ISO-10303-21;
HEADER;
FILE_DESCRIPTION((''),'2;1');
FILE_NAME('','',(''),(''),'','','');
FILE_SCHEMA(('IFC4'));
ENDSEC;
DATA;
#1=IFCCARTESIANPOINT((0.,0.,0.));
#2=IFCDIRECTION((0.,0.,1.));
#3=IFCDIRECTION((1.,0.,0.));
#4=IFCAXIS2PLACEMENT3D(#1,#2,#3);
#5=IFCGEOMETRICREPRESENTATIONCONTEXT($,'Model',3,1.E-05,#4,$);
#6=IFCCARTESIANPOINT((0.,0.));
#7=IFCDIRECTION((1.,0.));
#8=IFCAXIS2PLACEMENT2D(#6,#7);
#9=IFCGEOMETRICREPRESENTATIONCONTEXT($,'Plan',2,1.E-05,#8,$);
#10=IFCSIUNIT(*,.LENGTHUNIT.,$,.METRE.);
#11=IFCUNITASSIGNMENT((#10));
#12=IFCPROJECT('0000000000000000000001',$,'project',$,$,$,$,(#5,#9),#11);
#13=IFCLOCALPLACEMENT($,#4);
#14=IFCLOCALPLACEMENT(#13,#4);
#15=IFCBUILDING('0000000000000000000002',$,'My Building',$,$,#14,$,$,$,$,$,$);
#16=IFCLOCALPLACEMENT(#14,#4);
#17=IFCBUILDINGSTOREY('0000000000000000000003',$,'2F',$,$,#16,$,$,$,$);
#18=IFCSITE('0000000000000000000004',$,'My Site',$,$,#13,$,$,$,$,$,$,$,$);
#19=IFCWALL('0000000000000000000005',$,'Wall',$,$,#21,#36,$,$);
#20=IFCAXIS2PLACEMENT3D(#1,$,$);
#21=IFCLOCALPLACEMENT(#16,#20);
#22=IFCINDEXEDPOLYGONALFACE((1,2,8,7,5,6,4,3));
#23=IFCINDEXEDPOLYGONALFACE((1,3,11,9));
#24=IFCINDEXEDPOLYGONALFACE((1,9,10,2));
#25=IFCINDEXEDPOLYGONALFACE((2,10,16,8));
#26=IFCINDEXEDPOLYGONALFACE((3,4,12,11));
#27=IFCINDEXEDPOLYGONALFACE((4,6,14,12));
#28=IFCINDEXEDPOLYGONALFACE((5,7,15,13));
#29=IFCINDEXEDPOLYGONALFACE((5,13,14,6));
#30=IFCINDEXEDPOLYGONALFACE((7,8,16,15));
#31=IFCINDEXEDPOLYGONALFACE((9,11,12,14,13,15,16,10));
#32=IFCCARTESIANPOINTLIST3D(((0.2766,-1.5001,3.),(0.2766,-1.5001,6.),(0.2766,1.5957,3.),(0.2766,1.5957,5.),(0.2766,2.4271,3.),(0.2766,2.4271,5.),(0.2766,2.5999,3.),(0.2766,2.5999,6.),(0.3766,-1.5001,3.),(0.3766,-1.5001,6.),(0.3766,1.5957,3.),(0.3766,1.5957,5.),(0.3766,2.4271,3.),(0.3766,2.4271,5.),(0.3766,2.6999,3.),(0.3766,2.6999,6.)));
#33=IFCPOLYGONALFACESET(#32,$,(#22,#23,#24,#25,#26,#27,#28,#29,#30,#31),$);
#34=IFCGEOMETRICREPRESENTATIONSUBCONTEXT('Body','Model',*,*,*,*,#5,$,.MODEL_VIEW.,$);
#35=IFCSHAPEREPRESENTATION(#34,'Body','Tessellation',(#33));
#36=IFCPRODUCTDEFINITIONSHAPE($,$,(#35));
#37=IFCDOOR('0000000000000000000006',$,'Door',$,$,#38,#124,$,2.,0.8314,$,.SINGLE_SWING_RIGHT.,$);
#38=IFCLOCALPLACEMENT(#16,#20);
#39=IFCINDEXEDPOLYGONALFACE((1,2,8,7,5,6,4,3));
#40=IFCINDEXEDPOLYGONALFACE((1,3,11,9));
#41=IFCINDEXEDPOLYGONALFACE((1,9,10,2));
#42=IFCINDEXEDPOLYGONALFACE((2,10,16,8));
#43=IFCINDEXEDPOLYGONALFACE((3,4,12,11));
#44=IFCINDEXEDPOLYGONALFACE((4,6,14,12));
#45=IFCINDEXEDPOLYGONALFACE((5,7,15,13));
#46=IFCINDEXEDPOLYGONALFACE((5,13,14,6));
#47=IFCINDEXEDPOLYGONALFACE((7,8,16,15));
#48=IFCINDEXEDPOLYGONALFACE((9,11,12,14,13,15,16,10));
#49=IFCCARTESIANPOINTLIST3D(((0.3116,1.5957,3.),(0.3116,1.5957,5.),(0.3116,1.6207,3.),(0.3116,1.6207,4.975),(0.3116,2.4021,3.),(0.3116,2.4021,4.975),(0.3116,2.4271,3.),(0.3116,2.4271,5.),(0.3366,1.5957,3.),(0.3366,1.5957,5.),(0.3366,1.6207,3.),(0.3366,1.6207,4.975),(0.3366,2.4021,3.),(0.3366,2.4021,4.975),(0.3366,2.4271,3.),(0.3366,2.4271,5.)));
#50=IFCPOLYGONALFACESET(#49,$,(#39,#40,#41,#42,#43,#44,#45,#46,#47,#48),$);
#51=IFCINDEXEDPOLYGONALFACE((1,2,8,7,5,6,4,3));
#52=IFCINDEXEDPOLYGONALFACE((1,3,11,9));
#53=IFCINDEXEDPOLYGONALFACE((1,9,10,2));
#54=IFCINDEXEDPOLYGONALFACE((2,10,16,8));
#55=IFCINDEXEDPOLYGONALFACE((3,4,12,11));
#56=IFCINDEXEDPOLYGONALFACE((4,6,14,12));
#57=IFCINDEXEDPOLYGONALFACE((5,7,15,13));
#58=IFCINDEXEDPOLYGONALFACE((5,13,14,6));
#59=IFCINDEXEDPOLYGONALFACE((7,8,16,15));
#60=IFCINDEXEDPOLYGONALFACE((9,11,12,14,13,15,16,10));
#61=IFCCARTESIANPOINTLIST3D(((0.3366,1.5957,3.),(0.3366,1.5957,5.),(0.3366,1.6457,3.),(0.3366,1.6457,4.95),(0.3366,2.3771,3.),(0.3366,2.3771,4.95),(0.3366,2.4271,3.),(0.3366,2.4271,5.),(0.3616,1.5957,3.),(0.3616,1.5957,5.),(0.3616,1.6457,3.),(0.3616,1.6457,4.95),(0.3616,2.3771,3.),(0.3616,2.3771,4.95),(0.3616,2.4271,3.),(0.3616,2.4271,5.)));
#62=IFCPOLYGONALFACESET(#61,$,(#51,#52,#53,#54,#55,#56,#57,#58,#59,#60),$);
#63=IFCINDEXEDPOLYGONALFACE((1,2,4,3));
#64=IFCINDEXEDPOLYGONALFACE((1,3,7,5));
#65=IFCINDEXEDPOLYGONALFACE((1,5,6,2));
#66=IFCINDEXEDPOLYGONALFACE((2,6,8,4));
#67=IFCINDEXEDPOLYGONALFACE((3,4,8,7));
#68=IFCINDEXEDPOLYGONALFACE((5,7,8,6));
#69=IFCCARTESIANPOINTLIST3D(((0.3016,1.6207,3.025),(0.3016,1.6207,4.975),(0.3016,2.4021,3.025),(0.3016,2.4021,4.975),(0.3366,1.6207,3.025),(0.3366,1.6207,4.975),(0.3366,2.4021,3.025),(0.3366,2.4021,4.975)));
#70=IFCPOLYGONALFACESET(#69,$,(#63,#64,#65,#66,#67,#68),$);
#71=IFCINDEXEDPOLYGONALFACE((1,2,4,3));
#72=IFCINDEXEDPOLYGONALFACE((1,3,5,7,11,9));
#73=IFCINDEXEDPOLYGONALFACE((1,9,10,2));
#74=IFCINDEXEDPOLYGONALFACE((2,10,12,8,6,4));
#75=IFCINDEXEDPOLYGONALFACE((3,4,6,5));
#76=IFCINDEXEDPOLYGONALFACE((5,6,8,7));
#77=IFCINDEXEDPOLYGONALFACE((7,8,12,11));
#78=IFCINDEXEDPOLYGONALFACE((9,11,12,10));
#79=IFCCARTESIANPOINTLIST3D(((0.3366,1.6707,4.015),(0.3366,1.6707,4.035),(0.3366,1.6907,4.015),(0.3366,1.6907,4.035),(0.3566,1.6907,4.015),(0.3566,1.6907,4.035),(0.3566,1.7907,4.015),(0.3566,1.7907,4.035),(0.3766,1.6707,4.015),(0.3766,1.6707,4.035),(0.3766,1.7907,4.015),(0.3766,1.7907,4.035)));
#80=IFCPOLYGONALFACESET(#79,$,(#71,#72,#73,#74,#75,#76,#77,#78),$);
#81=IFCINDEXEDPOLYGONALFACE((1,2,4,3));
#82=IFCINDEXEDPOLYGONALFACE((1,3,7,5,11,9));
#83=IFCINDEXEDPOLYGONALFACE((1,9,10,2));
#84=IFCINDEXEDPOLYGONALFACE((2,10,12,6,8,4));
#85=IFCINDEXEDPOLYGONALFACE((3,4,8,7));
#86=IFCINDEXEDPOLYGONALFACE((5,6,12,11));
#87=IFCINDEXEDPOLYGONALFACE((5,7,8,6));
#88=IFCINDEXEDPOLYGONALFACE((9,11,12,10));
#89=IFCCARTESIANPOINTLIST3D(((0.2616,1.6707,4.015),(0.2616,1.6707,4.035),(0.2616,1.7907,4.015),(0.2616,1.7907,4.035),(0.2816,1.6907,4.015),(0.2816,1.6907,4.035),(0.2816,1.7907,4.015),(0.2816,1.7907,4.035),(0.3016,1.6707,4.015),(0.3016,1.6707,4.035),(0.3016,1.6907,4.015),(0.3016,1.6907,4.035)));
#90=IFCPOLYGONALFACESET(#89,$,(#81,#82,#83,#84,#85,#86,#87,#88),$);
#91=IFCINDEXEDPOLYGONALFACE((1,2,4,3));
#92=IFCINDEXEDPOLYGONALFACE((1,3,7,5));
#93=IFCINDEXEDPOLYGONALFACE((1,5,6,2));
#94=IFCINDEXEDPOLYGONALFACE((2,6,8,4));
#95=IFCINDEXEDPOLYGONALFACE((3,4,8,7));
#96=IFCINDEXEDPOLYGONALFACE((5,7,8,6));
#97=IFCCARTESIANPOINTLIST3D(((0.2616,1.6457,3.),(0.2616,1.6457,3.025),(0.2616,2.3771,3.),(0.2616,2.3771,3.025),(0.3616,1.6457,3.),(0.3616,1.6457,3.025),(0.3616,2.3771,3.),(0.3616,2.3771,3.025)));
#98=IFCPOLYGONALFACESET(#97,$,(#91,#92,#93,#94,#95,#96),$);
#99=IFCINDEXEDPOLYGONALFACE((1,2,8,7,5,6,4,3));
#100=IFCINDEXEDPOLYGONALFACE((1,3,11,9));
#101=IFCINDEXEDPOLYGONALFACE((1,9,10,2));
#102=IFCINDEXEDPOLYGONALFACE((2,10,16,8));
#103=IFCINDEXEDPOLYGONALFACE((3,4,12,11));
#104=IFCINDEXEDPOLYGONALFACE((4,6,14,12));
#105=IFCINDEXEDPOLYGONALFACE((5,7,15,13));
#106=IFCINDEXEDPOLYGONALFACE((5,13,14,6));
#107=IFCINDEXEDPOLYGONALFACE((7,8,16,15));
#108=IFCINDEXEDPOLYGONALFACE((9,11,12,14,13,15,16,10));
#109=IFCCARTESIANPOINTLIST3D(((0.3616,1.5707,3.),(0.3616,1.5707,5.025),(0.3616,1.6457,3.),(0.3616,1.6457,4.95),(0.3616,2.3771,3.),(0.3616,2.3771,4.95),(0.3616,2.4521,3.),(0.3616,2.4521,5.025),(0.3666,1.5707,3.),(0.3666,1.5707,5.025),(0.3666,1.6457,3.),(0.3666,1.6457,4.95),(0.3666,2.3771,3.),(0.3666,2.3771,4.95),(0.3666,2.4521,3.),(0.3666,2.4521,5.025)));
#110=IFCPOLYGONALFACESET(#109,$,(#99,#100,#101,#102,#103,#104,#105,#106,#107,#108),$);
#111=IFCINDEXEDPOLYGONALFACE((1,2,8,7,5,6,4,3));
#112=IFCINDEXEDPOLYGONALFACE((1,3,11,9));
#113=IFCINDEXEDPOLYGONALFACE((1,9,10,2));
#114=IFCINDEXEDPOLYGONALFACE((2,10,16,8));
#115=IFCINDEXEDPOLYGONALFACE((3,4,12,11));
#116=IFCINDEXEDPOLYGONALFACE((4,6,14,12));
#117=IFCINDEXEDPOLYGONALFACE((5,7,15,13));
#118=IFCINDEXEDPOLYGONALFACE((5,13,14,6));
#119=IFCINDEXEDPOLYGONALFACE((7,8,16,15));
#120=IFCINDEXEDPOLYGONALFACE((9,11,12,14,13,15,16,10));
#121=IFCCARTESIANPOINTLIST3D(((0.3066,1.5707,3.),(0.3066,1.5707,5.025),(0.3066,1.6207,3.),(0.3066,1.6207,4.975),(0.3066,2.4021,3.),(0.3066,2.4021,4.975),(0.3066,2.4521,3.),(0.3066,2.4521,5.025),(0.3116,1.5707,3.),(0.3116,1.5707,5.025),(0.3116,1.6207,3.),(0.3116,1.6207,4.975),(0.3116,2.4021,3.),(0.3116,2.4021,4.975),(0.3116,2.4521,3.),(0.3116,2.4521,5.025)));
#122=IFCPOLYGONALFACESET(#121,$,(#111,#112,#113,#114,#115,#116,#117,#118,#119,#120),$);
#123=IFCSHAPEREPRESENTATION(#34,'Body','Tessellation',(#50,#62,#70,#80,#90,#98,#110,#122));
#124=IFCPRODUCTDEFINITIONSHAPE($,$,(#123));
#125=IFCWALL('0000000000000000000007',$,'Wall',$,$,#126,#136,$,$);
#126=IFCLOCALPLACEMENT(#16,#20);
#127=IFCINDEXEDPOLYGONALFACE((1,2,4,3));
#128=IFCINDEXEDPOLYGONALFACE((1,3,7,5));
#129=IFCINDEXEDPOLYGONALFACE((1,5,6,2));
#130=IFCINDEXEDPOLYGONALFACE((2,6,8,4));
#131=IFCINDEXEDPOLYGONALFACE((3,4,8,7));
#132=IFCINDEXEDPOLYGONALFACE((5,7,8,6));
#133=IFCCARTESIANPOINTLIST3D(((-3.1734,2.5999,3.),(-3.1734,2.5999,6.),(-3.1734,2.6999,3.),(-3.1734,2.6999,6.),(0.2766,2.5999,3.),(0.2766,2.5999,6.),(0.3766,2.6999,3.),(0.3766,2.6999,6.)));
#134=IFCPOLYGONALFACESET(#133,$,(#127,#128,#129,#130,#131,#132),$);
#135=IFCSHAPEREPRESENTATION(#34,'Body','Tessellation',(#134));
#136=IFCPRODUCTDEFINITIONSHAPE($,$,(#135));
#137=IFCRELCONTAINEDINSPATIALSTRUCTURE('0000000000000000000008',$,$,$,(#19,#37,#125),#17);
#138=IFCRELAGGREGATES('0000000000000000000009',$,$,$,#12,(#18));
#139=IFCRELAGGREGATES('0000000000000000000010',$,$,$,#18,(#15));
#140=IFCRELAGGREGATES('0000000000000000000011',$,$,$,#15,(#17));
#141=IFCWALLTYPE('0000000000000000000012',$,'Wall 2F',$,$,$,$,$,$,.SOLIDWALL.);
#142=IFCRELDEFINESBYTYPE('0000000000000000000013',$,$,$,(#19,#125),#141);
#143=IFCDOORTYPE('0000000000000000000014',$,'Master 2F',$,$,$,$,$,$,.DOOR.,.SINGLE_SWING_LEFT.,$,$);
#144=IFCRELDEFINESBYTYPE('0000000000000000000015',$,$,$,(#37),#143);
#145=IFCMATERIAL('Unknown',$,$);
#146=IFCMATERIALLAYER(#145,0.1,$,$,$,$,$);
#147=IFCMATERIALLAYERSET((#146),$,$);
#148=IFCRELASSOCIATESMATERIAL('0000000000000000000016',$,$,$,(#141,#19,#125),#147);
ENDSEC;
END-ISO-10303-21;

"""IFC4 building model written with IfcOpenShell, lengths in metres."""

from ifc_helpers import new_model, entity, si_unit, frame, origin_with_axes, origin_2d_with_axis, place, context, subcontext, project, spatial, line, indexed_curve, outline, extrude, shape, source, transform, mapped, material, layer, layer_set, layer_usage, type_object, type_shapes, element, fill, save


model = new_model("IFC4")

# Units and contexts
model_context = context("Model", 3, precision=1e-05, world=origin_with_axes())
plan_context = context("Plan", 2, precision=1e-05, world=origin_2d_with_axis())
body_context_1 = subcontext(model_context, "Body", "Model", "MODEL_VIEW")
body_context_2 = subcontext(plan_context, "Body", "Plan", "PLAN_VIEW")
ifc_project = project(units=[si_unit("LENGTHUNIT", "METRE")], contexts=[model_context, plan_context])

# Site, building, storey
site_placement = place(None, origin_with_axes())
site = spatial("IfcSite", under=ifc_project, at=site_placement, Name="My Site")
building_placement = place(site_placement, origin_with_axes())
building = spatial("IfcBuilding", under=site, at=building_placement, Name="My Building")
storey_placement = place(building_placement, origin_with_axes())
storey = spatial("IfcBuildingStorey", under=building, at=storey_placement, Name="2F")

# Shared definitions
ifc_material = material(Name="Unknown")

# Shared definitions
ifc_layer = layer(ifc_material, 0.1)
ifc_layer_set = layer_set([ifc_layer])
wall_type = type_object("IfcWallType", Name="Wall 2F", PredefinedType="SOLIDWALL", material=ifc_layer_set)

# Wall, opening, door
ifc_layer_usage_1 = layer_usage(ifc_layer_set, "AXIS2", "POSITIVE", 0.0)
wall_1_placement = place(storey_placement, frame((0.3766, -1.6001, 3.0), z_axis=(0.0, 0.0, 1.0), x_axis=(0.0, 1.0, 0.0)))
wall_1 = element("IfcWall", 1, at=wall_1_placement, inside=storey, type_object=wall_type, material=ifc_layer_usage_1, Name="Wall", context=body_context_1, shape_type="SweptSolid", body=[
    extrude(outline(indexed_curve([(0.1, 0.0), (0.1, 0.1), (4.2, 0.1), (4.3, 0.0)], segments=[line(1, 2, 3, 4, 1)])), origin_with_axes(), (0.0, 0.0, 1.0), 3.0),
])
shared_shape_1 = source(origin_with_axes(), body_context_1, "Body", "SweptSolid", [
    extrude(outline(indexed_curve([(0.0, 0.0), (0.8314, 0.0), (0.8314, 2.0), (0.0, 2.0)], segments=[line(1, 2, 3, 4, 1)])), frame((0.0, -0.6, 0.0), z_axis=(0.0, -1.0, 0.0), x_axis=(1.0, 0.0, 0.0)), (0.0, 0.0, -1.0), 1.2),
])
opening_1_placement = place(wall_1_placement, frame((3.1958, 0.015, 0.0), z_axis=(0.0, 0.0, 1.0), x_axis=(1.0, 0.0, 0.0)))
opening_1 = element("IfcOpeningElement", 2, at=opening_1_placement, cuts=wall_1, PredefinedType="OPENING", context=body_context_1, shape_type="MappedRepresentation", body=[
    mapped(shared_shape_1, transform((0.0, 0.0, 0.0), x_axis=(1.0, 0.0, 0.0), y_axis=(0.0, 1.0, 0.0), z_axis=(0.0, 0.0, 1.0), scale=1.0)),
])
door_type_1 = type_object("IfcDoorType", Name="Master 2F", OperationType="SINGLE_SWING_LEFT", PredefinedType="DOOR")
shared_shape_2 = source(origin_with_axes(), body_context_1, "Body", "SweptSolid", [
    extrude(outline(indexed_curve([(0.0, 0.0), (0.0, 2.0), (0.8314, 2.0), (0.8314, 0.0), (0.8064, 0.0), (0.8064, 1.975), (0.025, 1.975), (0.025, 0.0)], segments=[line(1, 2, 3, 4, 5, 6, 7, 8, 1)])), frame((0.0, 0.025, 0.0), z_axis=(0.0, -1.0, 0.0), x_axis=(1.0, 0.0, 0.0)), (0.0, 0.0, -1.0), 0.025),
    extrude(outline(indexed_curve([(0.0, 0.0), (0.0, 2.0), (0.8314, 2.0), (0.8314, 0.0), (0.7814, 0.0), (0.7814, 1.95), (0.05, 1.95), (0.05, 0.0)], segments=[line(1, 2, 3, 4, 5, 6, 7, 8, 1)])), frame((0.0, 0.0, 0.0), z_axis=(0.0, -1.0, 0.0), x_axis=(1.0, 0.0, 0.0)), (0.0, 0.0, -1.0), 0.025),
    extrude(outline(indexed_curve([(0.0, 0.0), (0.7814, 0.0), (0.7814, 0.035), (0.0, 0.035)], segments=[line(1, 2, 3, 4, 1)])), frame((0.025, 0.025, 0.025), z_axis=(0.0, 0.0, 1.0), x_axis=(1.0, 0.0, 0.0)), (0.0, 0.0, 1.0), 1.95),
    extrude(outline(indexed_curve([(0.0, 0.0), (0.0, -0.04), (0.12, -0.04), (0.12, -0.02), (0.02, -0.02), (0.02, 0.0)], segments=[line(1, 2, 3, 4, 5, 6, 1)])), frame((0.075, 0.025, 1.015), z_axis=(0.0, 0.0, 1.0), x_axis=(1.0, 0.0, 0.0)), (0.0, 0.0, 1.0), 0.02),
    extrude(outline(indexed_curve([(0.0, 0.0), (0.0, 0.04), (0.12, 0.04), (0.12, 0.02), (0.02, 0.02), (0.02, 0.0)], segments=[line(1, 2, 3, 4, 5, 6, 1)])), frame((0.075, 0.06, 1.015), z_axis=(0.0, 0.0, 1.0), x_axis=(1.0, 0.0, 0.0)), (0.0, 0.0, 1.0), 0.02),
    extrude(outline(indexed_curve([(0.0, 0.0), (0.7314, 0.0), (0.7314, 0.1), (0.0, 0.1)], segments=[line(1, 2, 3, 4, 1)])), frame((0.05, 0.0, 0.0), z_axis=(0.0, 0.0, 1.0), x_axis=(1.0, 0.0, 0.0)), (0.0, 0.0, 1.0), 0.025),
    extrude(outline(indexed_curve([(0.0, 0.0), (0.0, 2.025), (0.8814, 2.025), (0.8814, 0.0), (0.8064, 0.0), (0.8064, 1.95), (0.075, 1.95), (0.075, 0.0)], segments=[line(1, 2, 3, 4, 5, 6, 7, 8, 1)])), frame((-0.025, -0.005, 0.0), z_axis=(0.0, -1.0, 0.0), x_axis=(1.0, 0.0, 0.0)), (0.0, 0.0, -1.0), 0.005),
    extrude(outline(indexed_curve([(0.0, 0.0), (0.0, 2.025), (0.8814, 2.025), (0.8814, 0.0), (0.8314, 0.0), (0.8314, 1.975), (0.05, 1.975), (0.05, 0.0)], segments=[line(1, 2, 3, 4, 5, 6, 7, 8, 1)])), frame((-0.025, 0.05, 0.0), z_axis=(0.0, -1.0, 0.0), x_axis=(1.0, 0.0, 0.0)), (0.0, 0.0, -1.0), 0.005),
])
shared_shape_3 = source(origin_with_axes(), body_context_2, "Body", "Curve2D", [
    entity("IfcIndexedPolyCurve", entity("IfcCartesianPointList2D", [[0.0, 0.0], [0.0, 0.05], [0.025, 0.05], [0.025, 0.025], [0.05, 0.025], [0.05, 0.0]]), [entity("IfcLineIndex", [1, 2, 3, 4, 5, 6, 1])]),
    entity("IfcIndexedPolyCurve", entity("IfcCartesianPointList2D", [[0.8314, 0.0], [0.8314, 0.05], [0.8064, 0.05], [0.8064, 0.025], [0.7814, 0.025], [0.7814, 0.0]]), [entity("IfcLineIndex", [1, 2, 3, 4, 5, 6, 1])]),
    entity("IfcTrimmedCurve", entity("IfcEllipse", entity("IfcAxis2Placement2D", entity("IfcCartesianPoint", [0.7714, 0.05]), entity("IfcDirection", [1.0, 0.0])), 0.7464, 0.7814), [entity("IfcCartesianPoint", [0.7714, 0.8314])], [entity("IfcCartesianPoint", [0.025, 0.05])], True, "CARTESIAN"),
    entity("IfcIndexedPolyCurve", entity("IfcCartesianPointList2D", [[0.8064, 0.05], [0.7714, 0.05], [0.7714, 0.8314], [0.8064, 0.8314]]), [entity("IfcLineIndex", [1, 2, 3, 4, 1])]),
])
type_shapes(door_type_1, [shared_shape_2, shared_shape_3])
door_1_placement = place(opening_1_placement, frame((0.0, 0.0, 0.0), z_axis=(0.0, 0.0, 1.0), x_axis=(1.0, 0.0, 0.0)))
door_1 = element("IfcDoor", 3, at=door_1_placement, inside=storey, type_object=door_type_1, Name="Door", OperationType="SINGLE_SWING_RIGHT", OverallHeight=2.0, OverallWidth=0.8314, shapes=[
    shape(body_context_1, "Body", "MappedRepresentation", [mapped(shared_shape_2, transform((0.0, 0.0, 0.0), x_axis=(1.0, 0.0, 0.0), y_axis=(0.0, 1.0, 0.0), z_axis=(0.0, 0.0, 1.0), scale=1.0))]),
    shape(body_context_2, "Body", "MappedRepresentation", [mapped(shared_shape_3, transform((0.0, 0.0, 0.0), x_axis=(1.0, 0.0, 0.0), y_axis=(0.0, 1.0, 0.0), z_axis=(0.0, 0.0, 1.0), scale=1.0))]),
])
fill(opening_1, door_1)

# Wall
ifc_layer_usage_2 = layer_usage(ifc_layer_set, "AXIS2", "POSITIVE", 0.0)
wall_2_placement = place(storey_placement, frame((0.3766, 2.6999, 3.0), z_axis=(0.0, 0.0, 1.0), x_axis=(-1.0, 0.0, 0.0)))
element("IfcWall", 4, at=wall_2_placement, inside=storey, type_object=wall_type, material=ifc_layer_usage_2, Name="Wall", context=body_context_1, shape_type="SweptSolid", body=[
    extrude(outline(indexed_curve([(0.0, 0.0), (0.1, 0.1), (3.55, 0.1), (3.55, 0.0)], segments=[line(1, 2, 3, 4, 1)])), origin_with_axes(), (0.0, 0.0, 1.0), 3.0),
])

save(model, "model.ifc")
